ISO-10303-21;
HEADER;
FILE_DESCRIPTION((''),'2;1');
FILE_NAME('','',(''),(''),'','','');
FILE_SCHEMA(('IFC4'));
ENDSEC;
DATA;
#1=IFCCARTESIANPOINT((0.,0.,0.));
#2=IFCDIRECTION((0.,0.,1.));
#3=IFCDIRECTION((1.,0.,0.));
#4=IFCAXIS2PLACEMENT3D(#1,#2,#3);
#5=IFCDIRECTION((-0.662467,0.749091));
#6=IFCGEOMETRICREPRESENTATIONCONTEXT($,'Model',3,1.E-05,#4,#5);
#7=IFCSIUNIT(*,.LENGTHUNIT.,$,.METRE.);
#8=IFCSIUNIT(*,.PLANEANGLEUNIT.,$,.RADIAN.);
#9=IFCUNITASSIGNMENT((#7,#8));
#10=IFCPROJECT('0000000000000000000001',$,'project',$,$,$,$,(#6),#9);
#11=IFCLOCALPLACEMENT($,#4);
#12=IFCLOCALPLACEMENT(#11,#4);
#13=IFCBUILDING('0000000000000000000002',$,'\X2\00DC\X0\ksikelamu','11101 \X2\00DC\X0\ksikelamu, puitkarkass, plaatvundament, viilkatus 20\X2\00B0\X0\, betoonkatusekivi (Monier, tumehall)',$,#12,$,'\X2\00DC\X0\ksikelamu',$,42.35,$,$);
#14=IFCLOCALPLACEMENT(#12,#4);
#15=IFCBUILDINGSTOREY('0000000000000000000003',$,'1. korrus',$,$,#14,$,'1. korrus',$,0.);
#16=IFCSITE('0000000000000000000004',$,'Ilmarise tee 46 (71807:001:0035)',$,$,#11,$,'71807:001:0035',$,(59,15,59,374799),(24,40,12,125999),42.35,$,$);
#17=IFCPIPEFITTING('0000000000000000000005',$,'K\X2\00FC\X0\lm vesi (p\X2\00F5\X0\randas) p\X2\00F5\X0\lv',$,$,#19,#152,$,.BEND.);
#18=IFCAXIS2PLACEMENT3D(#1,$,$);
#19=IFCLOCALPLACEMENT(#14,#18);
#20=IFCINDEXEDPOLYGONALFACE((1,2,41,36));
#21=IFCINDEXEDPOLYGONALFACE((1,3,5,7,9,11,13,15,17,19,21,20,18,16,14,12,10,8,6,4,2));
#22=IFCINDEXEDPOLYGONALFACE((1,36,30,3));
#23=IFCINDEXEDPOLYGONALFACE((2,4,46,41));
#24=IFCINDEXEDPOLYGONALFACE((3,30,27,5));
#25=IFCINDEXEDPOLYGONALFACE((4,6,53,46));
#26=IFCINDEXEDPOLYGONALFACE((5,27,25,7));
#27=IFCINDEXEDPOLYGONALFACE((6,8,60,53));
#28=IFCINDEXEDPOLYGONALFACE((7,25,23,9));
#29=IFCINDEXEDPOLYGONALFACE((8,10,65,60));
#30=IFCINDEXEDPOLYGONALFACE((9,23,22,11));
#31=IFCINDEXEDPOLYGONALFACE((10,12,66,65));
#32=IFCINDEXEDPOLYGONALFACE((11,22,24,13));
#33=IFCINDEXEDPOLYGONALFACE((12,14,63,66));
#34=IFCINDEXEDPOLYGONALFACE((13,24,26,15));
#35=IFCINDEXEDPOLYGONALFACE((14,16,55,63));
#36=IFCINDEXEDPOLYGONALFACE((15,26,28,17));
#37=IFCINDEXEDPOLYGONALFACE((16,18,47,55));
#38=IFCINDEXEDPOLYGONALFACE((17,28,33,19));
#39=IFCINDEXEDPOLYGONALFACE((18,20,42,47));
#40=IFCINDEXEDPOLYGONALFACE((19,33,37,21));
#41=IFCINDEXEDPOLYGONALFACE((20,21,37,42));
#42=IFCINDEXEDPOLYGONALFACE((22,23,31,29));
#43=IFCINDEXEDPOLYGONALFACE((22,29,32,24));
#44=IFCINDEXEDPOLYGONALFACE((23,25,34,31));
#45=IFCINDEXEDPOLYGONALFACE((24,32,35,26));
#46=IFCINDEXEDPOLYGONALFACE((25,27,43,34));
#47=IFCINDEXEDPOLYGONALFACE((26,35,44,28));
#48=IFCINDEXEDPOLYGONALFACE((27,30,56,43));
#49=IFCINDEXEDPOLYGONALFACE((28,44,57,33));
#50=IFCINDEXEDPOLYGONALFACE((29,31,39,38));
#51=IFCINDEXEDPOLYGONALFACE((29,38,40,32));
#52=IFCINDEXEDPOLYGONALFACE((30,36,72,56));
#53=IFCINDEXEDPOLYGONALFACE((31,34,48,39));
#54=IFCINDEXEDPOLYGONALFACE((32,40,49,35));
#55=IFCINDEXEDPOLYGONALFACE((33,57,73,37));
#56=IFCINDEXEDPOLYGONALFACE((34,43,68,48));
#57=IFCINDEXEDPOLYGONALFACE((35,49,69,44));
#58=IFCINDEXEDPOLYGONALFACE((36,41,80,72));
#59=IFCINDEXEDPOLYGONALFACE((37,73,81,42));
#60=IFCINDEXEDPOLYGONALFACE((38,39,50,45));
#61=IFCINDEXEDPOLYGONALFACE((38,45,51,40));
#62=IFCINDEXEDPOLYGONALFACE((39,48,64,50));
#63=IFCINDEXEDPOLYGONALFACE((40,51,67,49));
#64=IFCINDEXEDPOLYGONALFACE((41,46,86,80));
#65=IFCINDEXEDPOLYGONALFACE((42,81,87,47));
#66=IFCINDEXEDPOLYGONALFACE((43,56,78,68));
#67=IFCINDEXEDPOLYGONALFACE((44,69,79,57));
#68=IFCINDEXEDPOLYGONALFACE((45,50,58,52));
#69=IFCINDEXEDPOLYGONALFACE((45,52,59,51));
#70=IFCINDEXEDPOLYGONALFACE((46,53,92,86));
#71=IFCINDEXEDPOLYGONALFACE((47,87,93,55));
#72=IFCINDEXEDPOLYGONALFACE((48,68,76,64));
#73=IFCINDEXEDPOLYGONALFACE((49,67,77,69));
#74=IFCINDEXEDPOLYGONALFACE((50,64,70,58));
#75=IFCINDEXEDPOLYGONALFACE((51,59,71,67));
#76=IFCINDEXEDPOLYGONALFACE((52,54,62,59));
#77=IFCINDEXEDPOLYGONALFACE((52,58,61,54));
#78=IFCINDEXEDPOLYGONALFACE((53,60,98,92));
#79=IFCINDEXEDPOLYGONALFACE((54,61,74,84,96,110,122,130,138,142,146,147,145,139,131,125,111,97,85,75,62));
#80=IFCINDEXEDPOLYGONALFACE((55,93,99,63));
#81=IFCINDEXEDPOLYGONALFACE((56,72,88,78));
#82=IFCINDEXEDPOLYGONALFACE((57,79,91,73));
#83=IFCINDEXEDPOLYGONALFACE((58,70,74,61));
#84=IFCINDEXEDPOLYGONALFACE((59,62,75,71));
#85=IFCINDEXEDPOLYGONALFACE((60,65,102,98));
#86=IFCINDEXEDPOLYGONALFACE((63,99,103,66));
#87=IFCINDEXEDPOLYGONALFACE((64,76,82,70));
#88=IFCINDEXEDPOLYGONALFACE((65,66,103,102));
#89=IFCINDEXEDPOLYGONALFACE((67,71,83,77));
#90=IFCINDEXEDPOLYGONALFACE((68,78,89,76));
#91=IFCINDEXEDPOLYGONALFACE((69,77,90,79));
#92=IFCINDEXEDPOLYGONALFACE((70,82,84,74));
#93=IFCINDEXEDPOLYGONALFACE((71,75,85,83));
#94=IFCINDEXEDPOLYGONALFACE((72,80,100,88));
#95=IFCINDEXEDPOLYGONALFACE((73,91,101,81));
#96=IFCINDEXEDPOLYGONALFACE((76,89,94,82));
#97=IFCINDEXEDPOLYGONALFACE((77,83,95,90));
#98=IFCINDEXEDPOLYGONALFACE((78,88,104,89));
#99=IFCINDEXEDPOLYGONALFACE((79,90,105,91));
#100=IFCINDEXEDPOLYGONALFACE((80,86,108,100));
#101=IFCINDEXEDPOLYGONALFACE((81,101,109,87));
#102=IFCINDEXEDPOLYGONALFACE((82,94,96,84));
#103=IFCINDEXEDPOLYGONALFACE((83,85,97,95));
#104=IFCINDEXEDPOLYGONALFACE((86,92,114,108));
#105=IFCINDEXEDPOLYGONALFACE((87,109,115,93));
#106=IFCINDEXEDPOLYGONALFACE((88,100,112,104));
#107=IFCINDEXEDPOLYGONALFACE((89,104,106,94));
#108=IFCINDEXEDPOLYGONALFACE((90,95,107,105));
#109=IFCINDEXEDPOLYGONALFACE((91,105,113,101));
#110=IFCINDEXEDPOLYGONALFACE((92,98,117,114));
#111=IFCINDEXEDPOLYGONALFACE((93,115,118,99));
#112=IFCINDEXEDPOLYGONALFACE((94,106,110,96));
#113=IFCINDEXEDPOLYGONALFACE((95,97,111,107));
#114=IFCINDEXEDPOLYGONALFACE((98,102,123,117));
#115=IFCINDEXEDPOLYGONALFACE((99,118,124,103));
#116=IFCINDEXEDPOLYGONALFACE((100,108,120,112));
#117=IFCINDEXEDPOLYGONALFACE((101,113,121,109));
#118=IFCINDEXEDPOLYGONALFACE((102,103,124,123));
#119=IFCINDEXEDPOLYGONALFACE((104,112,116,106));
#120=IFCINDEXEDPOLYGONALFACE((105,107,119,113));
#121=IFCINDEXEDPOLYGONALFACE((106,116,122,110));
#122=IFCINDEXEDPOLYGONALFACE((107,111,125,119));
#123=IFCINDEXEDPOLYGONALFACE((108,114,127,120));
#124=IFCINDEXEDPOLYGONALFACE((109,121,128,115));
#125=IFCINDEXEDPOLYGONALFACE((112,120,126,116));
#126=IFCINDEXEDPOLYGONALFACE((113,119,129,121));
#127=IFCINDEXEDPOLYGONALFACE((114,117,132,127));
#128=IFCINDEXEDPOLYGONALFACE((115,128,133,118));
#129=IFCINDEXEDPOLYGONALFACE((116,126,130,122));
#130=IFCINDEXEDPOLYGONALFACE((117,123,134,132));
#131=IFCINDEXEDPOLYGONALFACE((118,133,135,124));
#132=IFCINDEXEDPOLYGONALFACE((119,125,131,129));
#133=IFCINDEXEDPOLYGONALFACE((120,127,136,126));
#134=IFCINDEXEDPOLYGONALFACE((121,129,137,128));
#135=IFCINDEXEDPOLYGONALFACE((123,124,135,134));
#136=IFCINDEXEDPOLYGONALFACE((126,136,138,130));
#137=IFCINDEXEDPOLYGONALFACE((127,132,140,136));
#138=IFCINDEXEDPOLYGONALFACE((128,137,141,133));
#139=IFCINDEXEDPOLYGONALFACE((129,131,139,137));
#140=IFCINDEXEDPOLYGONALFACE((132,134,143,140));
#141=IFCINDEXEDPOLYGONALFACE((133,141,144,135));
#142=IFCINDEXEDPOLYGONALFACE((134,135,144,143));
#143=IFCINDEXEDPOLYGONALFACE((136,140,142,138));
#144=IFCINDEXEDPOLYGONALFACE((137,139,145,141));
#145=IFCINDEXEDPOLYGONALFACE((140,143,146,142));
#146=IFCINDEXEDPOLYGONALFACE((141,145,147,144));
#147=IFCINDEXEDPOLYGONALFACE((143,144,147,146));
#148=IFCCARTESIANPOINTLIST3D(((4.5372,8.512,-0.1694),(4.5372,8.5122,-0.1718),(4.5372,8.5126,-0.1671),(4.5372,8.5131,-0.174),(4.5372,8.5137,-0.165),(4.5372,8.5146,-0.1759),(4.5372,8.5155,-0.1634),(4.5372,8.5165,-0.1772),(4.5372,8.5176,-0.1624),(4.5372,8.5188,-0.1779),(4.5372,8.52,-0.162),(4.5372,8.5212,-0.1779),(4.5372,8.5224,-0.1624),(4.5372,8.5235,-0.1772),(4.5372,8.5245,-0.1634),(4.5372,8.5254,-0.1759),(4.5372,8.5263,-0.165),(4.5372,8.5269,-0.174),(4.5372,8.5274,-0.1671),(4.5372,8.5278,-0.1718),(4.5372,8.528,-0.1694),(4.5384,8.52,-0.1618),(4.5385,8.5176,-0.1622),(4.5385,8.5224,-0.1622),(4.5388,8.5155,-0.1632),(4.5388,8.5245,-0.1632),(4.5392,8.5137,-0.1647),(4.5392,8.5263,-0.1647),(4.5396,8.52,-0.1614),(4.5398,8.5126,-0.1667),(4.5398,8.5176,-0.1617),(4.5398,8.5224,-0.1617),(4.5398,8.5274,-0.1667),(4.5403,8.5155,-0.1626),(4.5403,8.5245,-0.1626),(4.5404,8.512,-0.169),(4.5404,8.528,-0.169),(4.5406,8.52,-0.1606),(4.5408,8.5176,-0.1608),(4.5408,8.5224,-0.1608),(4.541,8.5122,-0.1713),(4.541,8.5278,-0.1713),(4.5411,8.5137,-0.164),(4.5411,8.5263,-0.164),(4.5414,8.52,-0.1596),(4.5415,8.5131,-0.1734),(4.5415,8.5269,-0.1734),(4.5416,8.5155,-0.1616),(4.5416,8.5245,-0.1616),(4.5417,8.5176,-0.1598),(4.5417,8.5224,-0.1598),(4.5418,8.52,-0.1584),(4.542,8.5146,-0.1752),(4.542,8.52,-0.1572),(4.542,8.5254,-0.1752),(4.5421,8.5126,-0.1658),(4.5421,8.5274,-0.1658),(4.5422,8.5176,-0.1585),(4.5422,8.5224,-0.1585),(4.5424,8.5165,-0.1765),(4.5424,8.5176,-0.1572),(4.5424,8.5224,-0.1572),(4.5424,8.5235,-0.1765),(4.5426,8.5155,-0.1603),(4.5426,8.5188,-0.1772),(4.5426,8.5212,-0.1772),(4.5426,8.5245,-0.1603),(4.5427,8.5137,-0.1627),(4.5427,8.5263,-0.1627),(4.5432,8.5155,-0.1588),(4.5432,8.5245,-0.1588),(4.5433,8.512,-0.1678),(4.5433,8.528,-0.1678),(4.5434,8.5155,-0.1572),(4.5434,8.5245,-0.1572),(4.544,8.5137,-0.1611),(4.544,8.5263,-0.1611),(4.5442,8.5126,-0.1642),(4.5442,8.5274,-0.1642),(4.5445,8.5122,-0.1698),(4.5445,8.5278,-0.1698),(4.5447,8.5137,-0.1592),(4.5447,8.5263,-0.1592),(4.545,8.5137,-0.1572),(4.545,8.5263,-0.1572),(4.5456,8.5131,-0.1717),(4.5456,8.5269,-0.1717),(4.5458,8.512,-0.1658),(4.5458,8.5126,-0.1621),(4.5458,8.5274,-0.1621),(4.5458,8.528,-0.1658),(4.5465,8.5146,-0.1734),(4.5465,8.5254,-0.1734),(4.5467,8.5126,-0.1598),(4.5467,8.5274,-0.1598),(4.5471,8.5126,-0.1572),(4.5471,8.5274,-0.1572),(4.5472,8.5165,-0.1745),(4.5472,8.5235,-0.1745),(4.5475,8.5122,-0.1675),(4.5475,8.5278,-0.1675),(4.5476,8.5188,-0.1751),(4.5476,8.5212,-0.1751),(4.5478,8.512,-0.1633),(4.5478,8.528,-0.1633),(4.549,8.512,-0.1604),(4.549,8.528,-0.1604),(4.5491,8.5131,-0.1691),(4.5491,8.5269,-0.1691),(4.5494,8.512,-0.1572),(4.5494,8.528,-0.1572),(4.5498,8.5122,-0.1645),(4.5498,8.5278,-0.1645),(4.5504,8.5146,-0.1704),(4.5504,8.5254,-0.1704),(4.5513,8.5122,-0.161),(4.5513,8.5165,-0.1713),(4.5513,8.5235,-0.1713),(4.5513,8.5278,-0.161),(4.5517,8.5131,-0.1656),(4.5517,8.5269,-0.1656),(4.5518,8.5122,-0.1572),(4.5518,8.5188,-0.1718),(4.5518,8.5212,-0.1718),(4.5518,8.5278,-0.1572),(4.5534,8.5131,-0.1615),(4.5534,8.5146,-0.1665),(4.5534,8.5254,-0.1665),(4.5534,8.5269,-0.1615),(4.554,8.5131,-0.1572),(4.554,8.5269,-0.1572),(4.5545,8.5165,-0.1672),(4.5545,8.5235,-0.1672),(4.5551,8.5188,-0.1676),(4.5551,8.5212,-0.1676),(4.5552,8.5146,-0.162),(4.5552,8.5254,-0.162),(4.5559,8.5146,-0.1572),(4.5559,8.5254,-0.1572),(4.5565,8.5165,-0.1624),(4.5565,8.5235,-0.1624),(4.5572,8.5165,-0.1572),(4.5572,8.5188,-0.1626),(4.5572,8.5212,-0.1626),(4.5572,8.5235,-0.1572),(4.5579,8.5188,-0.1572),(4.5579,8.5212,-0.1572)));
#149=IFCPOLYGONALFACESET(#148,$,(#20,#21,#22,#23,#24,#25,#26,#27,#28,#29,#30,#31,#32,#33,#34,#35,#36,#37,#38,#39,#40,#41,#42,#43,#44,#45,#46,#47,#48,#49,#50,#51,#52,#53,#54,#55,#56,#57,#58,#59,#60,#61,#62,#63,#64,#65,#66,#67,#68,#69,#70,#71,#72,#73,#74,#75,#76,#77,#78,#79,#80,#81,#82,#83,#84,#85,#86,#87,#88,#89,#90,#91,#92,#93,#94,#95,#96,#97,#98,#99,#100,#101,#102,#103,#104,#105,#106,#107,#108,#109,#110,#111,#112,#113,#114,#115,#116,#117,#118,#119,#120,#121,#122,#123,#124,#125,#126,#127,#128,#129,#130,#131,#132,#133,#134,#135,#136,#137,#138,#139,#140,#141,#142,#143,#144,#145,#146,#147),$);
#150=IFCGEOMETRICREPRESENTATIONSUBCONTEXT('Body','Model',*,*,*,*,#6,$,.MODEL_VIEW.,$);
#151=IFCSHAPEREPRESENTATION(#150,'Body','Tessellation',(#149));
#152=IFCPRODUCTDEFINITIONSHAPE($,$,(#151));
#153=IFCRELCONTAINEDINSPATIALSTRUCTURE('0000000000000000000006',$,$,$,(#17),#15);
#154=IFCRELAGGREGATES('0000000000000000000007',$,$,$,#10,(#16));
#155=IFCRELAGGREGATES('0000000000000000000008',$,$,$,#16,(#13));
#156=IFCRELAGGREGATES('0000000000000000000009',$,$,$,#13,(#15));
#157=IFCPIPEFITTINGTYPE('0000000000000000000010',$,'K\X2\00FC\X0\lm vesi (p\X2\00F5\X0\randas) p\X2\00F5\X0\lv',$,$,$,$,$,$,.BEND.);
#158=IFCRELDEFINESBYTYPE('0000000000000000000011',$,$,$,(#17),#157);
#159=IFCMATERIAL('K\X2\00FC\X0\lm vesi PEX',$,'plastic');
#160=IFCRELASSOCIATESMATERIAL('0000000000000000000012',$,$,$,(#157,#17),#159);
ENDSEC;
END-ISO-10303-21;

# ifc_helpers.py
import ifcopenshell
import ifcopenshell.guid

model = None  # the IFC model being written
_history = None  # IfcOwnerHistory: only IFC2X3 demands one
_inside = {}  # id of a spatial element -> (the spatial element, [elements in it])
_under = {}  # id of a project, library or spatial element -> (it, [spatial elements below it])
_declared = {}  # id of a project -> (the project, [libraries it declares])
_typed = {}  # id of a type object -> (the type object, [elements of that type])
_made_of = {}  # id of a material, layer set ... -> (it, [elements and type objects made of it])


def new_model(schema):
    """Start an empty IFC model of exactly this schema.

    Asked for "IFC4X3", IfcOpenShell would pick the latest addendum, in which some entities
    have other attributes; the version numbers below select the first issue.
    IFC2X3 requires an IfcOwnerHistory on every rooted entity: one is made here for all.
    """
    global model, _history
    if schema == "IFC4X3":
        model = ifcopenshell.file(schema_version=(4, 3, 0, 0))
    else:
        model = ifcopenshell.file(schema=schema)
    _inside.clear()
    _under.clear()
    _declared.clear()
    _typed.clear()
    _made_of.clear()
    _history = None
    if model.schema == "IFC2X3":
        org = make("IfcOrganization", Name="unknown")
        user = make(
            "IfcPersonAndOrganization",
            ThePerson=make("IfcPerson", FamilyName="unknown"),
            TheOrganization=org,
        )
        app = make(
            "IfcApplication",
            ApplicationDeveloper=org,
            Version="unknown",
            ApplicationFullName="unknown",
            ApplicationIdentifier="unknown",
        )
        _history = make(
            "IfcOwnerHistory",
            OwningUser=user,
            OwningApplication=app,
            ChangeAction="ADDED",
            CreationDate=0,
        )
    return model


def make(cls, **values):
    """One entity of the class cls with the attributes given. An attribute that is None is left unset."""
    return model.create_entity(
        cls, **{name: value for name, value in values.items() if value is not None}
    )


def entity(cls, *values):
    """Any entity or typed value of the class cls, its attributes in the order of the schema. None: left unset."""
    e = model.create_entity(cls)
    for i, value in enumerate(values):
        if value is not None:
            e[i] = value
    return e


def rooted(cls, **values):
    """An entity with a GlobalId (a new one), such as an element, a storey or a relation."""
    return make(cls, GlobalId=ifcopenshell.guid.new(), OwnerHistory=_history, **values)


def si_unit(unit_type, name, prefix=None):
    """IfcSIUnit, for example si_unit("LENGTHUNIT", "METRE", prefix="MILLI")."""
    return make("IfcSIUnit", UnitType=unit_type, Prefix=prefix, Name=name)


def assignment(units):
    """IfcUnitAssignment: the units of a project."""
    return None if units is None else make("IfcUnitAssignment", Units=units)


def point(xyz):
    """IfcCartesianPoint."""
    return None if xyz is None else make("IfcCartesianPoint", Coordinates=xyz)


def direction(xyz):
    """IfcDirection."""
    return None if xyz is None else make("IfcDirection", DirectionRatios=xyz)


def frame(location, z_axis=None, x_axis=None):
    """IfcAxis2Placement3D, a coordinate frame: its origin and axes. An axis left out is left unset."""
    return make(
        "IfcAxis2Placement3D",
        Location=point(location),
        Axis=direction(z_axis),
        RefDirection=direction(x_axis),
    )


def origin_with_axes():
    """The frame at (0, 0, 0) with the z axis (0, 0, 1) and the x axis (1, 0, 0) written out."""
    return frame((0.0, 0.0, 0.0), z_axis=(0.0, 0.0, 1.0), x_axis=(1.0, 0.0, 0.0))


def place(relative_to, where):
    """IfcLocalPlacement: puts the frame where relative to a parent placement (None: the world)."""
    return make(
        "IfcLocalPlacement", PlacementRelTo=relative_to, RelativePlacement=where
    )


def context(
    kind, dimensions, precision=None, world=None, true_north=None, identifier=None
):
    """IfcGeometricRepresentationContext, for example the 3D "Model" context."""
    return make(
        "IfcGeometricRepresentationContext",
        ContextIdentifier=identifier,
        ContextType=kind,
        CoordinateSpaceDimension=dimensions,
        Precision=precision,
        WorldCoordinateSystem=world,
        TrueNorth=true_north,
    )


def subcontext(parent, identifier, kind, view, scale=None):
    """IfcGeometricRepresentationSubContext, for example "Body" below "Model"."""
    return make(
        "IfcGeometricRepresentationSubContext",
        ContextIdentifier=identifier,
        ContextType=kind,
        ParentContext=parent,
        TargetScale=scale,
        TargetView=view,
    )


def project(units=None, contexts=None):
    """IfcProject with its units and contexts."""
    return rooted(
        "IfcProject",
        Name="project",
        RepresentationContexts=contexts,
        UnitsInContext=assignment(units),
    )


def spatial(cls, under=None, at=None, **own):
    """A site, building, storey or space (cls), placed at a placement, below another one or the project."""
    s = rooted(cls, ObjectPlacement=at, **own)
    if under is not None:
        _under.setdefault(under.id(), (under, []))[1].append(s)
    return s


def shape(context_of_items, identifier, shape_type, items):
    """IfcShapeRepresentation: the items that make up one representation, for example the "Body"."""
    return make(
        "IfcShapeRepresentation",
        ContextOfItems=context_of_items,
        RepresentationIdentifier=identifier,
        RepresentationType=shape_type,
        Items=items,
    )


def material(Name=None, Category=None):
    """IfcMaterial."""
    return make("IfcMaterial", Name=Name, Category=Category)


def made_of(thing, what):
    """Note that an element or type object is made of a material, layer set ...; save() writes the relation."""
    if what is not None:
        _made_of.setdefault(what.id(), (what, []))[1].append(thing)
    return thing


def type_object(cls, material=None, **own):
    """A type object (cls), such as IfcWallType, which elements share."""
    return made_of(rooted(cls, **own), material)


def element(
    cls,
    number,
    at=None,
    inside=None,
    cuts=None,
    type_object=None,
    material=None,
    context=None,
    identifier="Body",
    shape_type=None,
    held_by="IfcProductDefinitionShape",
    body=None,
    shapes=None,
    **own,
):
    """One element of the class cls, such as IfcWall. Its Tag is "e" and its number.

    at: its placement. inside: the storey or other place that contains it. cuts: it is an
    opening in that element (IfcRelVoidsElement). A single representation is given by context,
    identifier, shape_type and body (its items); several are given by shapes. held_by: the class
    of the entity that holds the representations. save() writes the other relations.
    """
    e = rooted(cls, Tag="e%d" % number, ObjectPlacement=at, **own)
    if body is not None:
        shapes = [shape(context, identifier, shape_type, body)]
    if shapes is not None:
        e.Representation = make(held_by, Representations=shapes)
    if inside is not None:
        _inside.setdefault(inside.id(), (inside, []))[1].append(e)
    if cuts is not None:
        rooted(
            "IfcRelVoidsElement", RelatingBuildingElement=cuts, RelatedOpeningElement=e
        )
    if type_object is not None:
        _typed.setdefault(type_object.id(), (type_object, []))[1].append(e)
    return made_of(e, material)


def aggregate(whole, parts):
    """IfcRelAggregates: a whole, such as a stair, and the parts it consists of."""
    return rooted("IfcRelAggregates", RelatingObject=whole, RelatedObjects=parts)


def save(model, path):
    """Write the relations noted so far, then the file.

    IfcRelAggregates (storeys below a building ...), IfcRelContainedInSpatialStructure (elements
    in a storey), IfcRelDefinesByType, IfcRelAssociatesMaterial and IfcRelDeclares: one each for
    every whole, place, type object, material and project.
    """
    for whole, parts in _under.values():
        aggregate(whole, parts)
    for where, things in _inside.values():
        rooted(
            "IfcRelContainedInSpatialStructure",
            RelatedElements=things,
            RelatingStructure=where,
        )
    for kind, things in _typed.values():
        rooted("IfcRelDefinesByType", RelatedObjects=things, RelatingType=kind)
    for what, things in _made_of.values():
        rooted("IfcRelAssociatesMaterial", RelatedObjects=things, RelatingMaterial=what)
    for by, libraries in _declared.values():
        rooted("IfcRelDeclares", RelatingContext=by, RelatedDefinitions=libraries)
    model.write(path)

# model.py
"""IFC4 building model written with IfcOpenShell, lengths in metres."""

from ifc_helpers import new_model, entity, si_unit, direction, frame, origin_with_axes, place, context, subcontext, project, spatial, material, type_object, element, save


model = new_model("IFC4")

# Units and contexts
model_context = context("Model", 3, precision=1e-05, world=origin_with_axes(), true_north=direction((-0.662467, 0.749091)))
body_context = subcontext(model_context, "Body", "Model", "MODEL_VIEW")
ifc_project = project(units=[si_unit("LENGTHUNIT", "METRE"), si_unit("PLANEANGLEUNIT", "RADIAN")], contexts=[model_context])

# Site, building, storey
site_placement = place(None, origin_with_axes())
site = spatial("IfcSite", under=ifc_project, at=site_placement, Name="Ilmarise tee 46 (71807:001:0035)", LongName="71807:001:0035", RefLatitude=(59, 15, 59, 374799), RefLongitude=(24, 40, 12, 125999), RefElevation=42.35)
building_placement = place(site_placement, origin_with_axes())
building = spatial("IfcBuilding", under=site, at=building_placement, Name="Üksikelamu", Description="11101 Üksikelamu, puitkarkass, plaatvundament, viilkatus 20°, betoonkatusekivi (Monier, tumehall)", LongName="Üksikelamu", ElevationOfRefHeight=42.35)
storey_placement = place(building_placement, origin_with_axes())
storey = spatial("IfcBuildingStorey", under=building, at=storey_placement, Name="1. korrus", LongName="1. korrus", Elevation=0.0)

# Pipe fitting
ifc_material_1 = material(Name="Külm vesi PEX", Category="plastic")
pipe_fitting_type_1 = type_object("IfcPipeFittingType", Name="Külm vesi (põrandas) põlv", PredefinedType="BEND", material=ifc_material_1)
pipe_fitting_1_placement = place(storey_placement, frame((4.55, 8.52, -0.17), z_axis=(0.0, 0.0, 1.0), x_axis=(1.0, 0.0, 0.0)))
element("IfcPipeFitting", 1, at=pipe_fitting_1_placement, inside=storey, type_object=pipe_fitting_type_1, material=ifc_material_1, Name="Külm vesi (põrandas) põlv", PredefinedType="BEND", context=body_context, shape_type="SweptSolid", body=[
    entity("IfcRevolvedAreaSolid", entity("IfcCircleProfileDef", "AREA", None, None, 0.008), entity("IfcAxis2Placement3D", entity("IfcCartesianPoint", [-0.0128, 0.0, 0.0]), entity("IfcDirection", [1.0, 0.0, 0.0]), entity("IfcDirection", [0.0, 0.0, 1.0])), entity("IfcAxis1Placement", entity("IfcCartesianPoint", [0.0128, 0.0, 0.0]), entity("IfcDirection", [0.0, 1.0, 0.0])), 1.570796),
])

save(model, "model.ifc")
